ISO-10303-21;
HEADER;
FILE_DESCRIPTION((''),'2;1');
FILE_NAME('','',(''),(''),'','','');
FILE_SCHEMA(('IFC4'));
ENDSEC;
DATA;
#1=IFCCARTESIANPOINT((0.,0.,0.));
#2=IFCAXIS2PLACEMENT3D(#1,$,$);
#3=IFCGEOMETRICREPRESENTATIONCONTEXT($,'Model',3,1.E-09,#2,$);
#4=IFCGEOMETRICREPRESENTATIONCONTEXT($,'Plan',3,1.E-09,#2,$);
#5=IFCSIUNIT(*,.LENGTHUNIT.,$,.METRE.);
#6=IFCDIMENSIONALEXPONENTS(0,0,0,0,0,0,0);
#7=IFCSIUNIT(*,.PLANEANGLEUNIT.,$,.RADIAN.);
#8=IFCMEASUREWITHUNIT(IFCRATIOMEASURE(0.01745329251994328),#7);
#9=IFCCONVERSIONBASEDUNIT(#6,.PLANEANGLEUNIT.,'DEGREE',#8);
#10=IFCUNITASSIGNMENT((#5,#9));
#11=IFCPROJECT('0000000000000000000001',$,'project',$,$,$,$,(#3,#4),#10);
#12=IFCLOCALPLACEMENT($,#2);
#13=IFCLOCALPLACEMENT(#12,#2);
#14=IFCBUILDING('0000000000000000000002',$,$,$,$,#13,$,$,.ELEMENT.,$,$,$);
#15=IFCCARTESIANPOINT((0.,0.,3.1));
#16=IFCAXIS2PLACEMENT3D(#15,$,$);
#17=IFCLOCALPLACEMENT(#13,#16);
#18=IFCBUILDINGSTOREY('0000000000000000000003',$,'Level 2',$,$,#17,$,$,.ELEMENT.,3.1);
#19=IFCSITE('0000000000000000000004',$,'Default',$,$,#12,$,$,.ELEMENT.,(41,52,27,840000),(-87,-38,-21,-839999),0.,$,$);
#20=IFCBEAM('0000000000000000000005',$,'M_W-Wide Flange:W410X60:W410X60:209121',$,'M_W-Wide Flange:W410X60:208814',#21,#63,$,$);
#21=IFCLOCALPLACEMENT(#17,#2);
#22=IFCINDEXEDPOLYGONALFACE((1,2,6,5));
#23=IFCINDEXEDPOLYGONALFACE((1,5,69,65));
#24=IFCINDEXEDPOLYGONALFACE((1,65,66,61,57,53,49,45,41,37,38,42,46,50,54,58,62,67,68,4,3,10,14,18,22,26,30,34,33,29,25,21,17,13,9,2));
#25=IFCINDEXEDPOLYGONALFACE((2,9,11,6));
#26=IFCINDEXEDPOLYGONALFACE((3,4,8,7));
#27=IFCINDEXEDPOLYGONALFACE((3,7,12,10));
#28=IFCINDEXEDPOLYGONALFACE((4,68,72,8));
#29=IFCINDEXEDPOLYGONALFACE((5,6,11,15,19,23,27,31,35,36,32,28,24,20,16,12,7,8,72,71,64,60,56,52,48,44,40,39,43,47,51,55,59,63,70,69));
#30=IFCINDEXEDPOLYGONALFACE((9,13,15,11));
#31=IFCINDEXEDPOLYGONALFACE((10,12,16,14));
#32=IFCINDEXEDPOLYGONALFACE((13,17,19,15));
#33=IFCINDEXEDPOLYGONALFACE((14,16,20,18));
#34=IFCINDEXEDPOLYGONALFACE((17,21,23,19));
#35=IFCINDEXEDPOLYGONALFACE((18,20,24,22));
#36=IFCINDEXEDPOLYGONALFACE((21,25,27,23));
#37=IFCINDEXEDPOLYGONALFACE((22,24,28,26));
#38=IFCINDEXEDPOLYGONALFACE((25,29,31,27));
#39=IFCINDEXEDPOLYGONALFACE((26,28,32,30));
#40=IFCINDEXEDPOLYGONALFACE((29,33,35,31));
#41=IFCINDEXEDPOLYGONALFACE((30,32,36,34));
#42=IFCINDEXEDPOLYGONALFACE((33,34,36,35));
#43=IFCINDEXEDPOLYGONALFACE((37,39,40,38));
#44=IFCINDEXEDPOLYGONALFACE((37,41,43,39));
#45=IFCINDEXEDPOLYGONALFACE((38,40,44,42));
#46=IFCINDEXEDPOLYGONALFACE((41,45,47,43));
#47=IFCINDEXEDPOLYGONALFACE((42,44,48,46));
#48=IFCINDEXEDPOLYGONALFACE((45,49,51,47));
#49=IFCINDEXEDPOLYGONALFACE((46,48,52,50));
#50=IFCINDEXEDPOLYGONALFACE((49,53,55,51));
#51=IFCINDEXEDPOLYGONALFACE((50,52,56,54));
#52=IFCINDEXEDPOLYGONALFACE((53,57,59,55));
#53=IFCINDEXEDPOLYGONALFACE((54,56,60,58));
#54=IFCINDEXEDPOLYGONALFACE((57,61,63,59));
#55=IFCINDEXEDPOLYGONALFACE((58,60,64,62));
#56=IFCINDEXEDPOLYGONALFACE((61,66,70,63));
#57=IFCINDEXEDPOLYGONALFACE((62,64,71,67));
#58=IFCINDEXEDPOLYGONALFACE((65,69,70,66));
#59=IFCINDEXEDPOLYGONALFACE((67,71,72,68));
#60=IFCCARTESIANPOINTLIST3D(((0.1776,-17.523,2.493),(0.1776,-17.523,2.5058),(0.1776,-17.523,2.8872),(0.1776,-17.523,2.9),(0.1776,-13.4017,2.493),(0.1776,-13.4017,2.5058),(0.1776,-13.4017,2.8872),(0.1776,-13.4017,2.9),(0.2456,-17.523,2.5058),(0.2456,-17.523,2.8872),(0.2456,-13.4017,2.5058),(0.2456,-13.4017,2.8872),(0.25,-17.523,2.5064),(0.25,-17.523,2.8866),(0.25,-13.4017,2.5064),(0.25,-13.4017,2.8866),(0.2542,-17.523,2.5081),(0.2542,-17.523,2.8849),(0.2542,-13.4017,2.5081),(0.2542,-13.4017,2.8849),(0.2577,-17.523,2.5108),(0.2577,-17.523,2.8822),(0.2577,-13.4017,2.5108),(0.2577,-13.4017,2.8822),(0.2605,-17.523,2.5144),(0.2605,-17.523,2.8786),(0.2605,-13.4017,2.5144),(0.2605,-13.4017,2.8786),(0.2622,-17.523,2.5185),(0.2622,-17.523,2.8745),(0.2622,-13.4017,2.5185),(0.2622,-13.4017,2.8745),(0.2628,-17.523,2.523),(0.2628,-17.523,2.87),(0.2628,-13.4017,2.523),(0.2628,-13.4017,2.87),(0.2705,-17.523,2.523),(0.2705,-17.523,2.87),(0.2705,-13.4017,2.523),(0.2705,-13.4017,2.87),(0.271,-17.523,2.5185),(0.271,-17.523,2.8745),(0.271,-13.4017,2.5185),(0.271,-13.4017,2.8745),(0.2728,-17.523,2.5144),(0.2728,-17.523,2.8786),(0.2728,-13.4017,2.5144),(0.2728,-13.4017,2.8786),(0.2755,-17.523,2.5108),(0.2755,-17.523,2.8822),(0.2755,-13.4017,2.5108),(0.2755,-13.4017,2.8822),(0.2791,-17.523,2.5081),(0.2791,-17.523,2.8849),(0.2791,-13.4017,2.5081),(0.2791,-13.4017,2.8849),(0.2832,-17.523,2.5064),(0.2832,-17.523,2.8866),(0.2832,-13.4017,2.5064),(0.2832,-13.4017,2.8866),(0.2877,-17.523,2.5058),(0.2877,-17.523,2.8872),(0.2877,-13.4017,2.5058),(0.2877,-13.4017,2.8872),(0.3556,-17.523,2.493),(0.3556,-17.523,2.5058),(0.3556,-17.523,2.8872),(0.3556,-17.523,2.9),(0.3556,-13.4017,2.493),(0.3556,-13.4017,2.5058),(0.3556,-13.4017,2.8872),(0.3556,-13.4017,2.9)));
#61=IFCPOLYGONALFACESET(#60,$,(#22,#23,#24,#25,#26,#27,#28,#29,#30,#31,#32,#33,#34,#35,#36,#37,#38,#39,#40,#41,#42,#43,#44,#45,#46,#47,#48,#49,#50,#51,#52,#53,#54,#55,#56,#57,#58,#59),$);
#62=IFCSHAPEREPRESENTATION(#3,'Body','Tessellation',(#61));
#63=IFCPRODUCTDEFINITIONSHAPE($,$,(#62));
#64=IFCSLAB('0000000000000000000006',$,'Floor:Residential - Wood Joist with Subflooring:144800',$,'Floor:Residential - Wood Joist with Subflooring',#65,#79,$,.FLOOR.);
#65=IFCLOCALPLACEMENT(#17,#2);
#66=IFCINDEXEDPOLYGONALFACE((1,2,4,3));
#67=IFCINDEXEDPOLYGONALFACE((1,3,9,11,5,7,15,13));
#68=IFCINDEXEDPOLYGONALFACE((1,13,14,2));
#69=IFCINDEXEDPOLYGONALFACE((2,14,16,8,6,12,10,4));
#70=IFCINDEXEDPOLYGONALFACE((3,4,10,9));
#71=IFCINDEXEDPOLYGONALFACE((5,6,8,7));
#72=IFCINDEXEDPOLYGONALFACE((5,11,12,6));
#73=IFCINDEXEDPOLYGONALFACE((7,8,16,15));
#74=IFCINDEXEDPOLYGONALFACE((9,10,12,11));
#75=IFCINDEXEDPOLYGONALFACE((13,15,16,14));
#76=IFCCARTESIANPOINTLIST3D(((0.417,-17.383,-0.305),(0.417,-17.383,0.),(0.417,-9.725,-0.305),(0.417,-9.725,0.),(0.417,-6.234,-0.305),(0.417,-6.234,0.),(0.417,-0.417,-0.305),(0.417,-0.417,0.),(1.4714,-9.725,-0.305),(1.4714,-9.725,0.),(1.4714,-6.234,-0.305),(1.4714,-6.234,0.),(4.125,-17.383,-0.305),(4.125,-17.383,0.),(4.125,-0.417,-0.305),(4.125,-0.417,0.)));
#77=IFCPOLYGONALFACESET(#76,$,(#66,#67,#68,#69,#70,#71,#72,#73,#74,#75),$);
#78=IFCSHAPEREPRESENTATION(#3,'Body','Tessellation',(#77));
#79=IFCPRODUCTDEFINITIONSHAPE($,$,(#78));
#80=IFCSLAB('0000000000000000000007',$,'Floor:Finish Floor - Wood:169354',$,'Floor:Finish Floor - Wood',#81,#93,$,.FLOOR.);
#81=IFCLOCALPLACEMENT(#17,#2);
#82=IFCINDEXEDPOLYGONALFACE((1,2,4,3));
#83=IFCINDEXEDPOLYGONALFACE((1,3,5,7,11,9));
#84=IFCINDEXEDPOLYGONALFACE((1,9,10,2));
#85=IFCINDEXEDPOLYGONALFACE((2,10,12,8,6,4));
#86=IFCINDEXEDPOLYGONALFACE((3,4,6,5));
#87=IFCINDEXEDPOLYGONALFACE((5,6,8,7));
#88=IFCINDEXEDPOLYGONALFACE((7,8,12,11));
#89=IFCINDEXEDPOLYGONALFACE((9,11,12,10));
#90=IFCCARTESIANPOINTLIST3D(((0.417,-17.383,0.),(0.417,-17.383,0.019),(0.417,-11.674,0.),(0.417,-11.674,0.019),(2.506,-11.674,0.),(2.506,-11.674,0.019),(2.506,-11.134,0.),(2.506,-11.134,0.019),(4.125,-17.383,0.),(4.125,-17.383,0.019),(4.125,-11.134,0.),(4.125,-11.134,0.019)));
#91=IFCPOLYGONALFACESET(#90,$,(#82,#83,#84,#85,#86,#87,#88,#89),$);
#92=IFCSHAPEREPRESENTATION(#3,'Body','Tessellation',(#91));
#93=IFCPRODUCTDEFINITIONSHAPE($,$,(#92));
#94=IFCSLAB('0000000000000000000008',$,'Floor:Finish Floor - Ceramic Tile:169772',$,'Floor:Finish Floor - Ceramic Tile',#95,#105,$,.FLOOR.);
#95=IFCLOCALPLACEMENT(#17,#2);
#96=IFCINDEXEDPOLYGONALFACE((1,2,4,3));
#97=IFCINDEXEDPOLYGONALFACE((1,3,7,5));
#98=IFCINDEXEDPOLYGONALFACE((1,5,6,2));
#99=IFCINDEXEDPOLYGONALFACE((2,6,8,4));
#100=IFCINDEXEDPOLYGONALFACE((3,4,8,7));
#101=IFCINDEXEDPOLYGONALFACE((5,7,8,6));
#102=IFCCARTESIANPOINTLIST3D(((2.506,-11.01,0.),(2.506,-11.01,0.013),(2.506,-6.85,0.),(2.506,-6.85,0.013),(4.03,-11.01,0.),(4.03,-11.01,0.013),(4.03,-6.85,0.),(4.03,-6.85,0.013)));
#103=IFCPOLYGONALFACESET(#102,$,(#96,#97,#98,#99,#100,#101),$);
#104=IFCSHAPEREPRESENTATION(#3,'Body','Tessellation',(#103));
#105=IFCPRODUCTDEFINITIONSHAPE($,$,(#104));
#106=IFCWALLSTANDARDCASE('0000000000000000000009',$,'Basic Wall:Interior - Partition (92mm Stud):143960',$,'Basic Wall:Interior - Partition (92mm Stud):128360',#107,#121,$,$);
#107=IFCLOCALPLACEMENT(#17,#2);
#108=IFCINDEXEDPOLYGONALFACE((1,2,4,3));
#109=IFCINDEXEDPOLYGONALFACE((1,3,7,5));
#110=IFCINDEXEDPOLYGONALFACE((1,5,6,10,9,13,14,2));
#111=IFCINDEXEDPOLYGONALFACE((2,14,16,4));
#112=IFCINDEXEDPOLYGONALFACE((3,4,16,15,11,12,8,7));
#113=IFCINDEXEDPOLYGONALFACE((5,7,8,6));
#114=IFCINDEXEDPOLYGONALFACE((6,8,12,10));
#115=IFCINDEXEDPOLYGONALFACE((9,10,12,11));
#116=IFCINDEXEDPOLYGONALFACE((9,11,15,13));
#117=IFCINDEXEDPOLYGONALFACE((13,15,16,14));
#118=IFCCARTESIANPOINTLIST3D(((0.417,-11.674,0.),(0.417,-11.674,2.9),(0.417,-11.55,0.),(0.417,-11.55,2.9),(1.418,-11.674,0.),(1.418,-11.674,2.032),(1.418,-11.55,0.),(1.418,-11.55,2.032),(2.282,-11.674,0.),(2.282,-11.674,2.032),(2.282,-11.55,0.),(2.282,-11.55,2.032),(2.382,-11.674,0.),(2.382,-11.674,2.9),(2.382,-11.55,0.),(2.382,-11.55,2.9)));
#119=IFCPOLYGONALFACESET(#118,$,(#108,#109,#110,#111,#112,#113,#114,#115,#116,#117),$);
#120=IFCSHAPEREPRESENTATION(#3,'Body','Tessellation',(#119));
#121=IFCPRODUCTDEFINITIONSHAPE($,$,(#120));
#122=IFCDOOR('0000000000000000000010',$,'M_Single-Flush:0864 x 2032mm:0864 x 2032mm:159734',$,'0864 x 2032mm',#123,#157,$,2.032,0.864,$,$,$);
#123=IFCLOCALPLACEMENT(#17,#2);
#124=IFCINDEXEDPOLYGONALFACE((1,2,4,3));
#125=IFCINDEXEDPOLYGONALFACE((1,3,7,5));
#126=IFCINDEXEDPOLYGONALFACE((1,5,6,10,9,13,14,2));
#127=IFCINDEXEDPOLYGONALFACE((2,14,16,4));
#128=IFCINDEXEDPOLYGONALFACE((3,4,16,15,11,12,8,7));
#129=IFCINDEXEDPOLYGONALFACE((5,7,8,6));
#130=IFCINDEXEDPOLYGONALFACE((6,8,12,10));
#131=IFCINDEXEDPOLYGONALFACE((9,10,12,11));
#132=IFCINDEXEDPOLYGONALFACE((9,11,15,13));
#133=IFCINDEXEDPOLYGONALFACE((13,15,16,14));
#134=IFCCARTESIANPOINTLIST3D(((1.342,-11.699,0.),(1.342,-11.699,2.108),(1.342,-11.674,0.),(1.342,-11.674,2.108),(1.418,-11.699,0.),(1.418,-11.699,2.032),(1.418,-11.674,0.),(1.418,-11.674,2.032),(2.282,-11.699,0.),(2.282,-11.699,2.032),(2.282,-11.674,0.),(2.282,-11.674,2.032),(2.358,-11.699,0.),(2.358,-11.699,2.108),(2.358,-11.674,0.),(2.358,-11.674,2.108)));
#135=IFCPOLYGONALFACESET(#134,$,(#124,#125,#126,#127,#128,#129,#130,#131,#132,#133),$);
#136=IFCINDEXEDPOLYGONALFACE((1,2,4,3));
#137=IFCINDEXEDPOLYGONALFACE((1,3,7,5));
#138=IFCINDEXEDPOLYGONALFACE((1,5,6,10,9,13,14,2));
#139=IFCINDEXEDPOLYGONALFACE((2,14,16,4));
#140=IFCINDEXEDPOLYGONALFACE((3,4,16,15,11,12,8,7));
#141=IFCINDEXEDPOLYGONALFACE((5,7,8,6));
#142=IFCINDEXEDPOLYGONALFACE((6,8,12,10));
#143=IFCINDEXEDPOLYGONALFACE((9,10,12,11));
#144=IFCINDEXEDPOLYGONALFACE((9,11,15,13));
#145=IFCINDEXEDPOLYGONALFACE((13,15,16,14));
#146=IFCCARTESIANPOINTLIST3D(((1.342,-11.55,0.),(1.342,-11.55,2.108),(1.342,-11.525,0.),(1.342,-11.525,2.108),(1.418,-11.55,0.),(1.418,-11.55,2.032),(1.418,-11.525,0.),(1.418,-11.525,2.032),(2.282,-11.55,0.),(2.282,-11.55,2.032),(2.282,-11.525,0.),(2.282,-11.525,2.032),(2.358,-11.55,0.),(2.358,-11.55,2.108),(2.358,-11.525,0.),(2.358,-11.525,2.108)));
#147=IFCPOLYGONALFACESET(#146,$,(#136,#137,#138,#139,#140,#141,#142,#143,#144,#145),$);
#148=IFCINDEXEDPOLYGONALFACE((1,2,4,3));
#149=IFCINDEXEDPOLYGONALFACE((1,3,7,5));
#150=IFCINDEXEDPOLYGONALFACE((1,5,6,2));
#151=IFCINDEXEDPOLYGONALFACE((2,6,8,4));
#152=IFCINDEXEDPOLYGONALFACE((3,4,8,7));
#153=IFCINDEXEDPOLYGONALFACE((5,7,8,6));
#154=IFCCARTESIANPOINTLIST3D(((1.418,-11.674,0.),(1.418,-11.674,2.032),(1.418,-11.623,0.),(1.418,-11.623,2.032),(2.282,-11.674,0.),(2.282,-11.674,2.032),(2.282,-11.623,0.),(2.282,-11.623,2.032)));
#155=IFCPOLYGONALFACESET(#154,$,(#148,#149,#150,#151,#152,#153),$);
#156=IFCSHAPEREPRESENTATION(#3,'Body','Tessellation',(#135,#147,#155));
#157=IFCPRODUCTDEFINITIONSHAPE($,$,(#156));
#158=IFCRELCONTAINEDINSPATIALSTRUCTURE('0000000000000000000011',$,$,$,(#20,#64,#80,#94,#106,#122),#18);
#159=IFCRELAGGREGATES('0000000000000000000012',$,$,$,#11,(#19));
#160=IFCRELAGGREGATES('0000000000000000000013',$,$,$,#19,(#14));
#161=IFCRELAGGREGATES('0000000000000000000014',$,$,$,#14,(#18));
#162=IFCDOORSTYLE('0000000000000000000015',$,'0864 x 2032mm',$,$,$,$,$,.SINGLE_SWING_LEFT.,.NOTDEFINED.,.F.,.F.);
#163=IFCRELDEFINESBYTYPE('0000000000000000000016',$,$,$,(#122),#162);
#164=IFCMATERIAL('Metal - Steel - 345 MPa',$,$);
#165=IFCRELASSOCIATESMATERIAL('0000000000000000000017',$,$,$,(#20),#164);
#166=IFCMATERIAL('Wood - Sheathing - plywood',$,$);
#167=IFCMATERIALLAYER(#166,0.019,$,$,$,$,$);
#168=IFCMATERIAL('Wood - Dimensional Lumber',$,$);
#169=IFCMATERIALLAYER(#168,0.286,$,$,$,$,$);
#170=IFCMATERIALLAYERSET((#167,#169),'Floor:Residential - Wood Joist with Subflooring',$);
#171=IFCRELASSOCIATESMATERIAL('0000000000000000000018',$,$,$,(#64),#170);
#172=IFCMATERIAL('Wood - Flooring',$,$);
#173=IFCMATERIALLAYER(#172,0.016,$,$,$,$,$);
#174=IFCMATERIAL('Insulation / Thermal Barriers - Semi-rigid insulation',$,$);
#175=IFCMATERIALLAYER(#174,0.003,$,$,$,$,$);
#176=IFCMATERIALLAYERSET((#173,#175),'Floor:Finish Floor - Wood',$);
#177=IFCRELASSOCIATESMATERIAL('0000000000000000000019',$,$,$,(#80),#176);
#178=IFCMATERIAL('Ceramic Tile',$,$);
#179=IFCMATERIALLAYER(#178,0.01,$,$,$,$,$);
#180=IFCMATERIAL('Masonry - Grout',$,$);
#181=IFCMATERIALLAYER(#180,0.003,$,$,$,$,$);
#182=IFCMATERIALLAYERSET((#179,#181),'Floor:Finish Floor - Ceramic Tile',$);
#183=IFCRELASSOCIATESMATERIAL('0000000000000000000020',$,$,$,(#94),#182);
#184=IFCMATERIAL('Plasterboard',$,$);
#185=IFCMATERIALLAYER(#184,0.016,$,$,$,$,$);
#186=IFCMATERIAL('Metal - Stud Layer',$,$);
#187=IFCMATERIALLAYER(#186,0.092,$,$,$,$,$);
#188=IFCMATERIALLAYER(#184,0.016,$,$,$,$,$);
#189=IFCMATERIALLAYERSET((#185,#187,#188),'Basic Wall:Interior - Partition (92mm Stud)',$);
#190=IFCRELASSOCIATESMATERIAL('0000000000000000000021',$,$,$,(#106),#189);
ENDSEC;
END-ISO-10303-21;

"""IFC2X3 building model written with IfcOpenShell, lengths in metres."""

from ifc_helpers import new_model, entity, si_unit, converted_unit, frame, frame_2d, origin, origin_2d_with_axis, place, context, project, spatial, polyline, circle_curve, parameter, trimmed, segment, composite_curve, rectangle, outline, extrude, source, transform, mapped, material, layer, layer_set, layer_usage, type_object, type_shapes, element, fill, save


model = new_model("IFC2X3")

# Units and contexts
model_context = context("Model", 3, precision=1e-09, world=origin())
plan_context = context("Plan", 3, precision=1e-09, world=origin())
ifc_project = project(units=[si_unit("LENGTHUNIT", "METRE"), converted_unit("PLANEANGLEUNIT", "DEGREE", entity("IfcRatioMeasure", 0.01745329251994328), si_unit("PLANEANGLEUNIT", "RADIAN"), dimensions=[0, 0, 0, 0, 0, 0, 0])], contexts=[model_context, plan_context])

# Site, building, storey
site_placement = place(None, origin())
site = spatial("IfcSite", under=ifc_project, at=site_placement, Name="Default", CompositionType="ELEMENT", RefLatitude=(41, 52, 27, 840000), RefLongitude=(-87, -38, -21, -839999), RefElevation=0.0)
building_placement = place(site_placement, origin())
building = spatial("IfcBuilding", under=site, at=building_placement, CompositionType="ELEMENT")
storey_placement = place(building_placement, frame((0.0, 0.0, 3.1)))
storey = spatial("IfcBuildingStorey", under=building, at=storey_placement, Name="Level 2", CompositionType="ELEMENT", Elevation=3.1)

# Beam
ifc_material_1 = material(Name="Metal - Steel - 345 MPa")
beam_placement = place(storey_placement, frame((0.2666, -13.4017, 2.9), z_axis=(0.0, 0.0, 1.0), x_axis=(-1.0, 0.0, 0.0)))
element("IfcBeam", 1, at=beam_placement, inside=storey, material=ifc_material_1, Name="M_W-Wide Flange:W410X60:W410X60:209121", ObjectType="M_W-Wide Flange:W410X60:208814", context=model_context, shape_type="SweptSolid", body=[
    extrude(outline(composite_curve([segment(polyline([(0.1907, -0.089), (0.2035, -0.089)]), True, "CONTINUOUS"), segment(polyline([(0.2035, -0.089), (0.2035, 0.089)]), True, "CONTINUOUS"), segment(polyline([(0.2035, 0.089), (0.1907, 0.089)]), True, "CONTINUOUS"), segment(polyline([(0.1907, 0.089), (0.1907, 0.021)]), True, "CONTINUOUS"), segment(trimmed(circle_curve(frame_2d((0.1735, 0.021), x_axis=(1.0, 0.0)), 0.0172), [parameter(270.0)], [parameter(360.0)], True, "PARAMETER"), False, "CONTINUOUS"), segment(polyline([(0.1735, 0.0038), (-0.1735, 0.0038)]), True, "CONTINUOUS"), segment(trimmed(circle_curve(frame_2d((-0.1735, 0.021), x_axis=(0.0, -1.0)), 0.0172), [parameter(270.0)], [parameter(360.0)], True, "PARAMETER"), False, "CONTINUOUS"), segment(polyline([(-0.1907, 0.021), (-0.1907, 0.089)]), True, "CONTINUOUS"), segment(polyline([(-0.1907, 0.089), (-0.2035, 0.089)]), True, "CONTINUOUS"), segment(polyline([(-0.2035, 0.089), (-0.2035, -0.089)]), True, "CONTINUOUS"), segment(polyline([(-0.2035, -0.089), (-0.1907, -0.089)]), True, "CONTINUOUS"), segment(polyline([(-0.1907, -0.089), (-0.1907, -0.0211)]), True, "CONTINUOUS"), segment(trimmed(circle_curve(frame_2d((-0.1735, -0.0211), x_axis=(-1.0, 0.0)), 0.0172), [parameter(270.0)], [parameter(0.0)], True, "PARAMETER"), False, "CONTINUOUS"), segment(polyline([(-0.1735, -0.0039), (0.1735, -0.0039)]), True, "CONTINUOUS"), segment(trimmed(circle_curve(frame_2d((0.1735, -0.0211), x_axis=(0.0, 1.0)), 0.0172), [parameter(270.0)], [parameter(0.0)], True, "PARAMETER"), False, "CONTINUOUS"), segment(polyline([(0.1907, -0.0211), (0.1907, -0.089)]), True, "CONTINUOUS")], self_intersect=False)), frame((0.0, 4.1213, -0.2035), z_axis=(0.0, -1.0, 0.0), x_axis=(0.0, 0.0, -1.0)), (0.0, 0.0, 1.0), 4.1213),
])

# Slabs
ifc_material_2 = material(Name="Wood - Sheathing - plywood")
ifc_layer_1 = layer(ifc_material_2, 0.019)
ifc_material_3 = material(Name="Wood - Dimensional Lumber")
ifc_layer_2 = layer(ifc_material_3, 0.286)
ifc_layer_set_1 = layer_set([ifc_layer_1, ifc_layer_2], Name="Floor:Residential - Wood Joist with Subflooring")
ifc_layer_usage_1 = layer_usage(ifc_layer_set_1, "AXIS3", "POSITIVE", 0.0)
slab_1_placement = place(storey_placement, frame((0.417, -17.383, -0.305)))
element("IfcSlab", 2, at=slab_1_placement, inside=storey, material=ifc_layer_usage_1, Name="Floor:Residential - Wood Joist with Subflooring:144800", ObjectType="Floor:Residential - Wood Joist with Subflooring", PredefinedType="FLOOR", context=model_context, shape_type="SweptSolid", body=[
    extrude(outline(polyline([(-1.854, 8.483), (-1.854, -8.483), (1.854, -8.483), (1.854, -0.825), (0.7996, -0.825), (0.7996, 2.666), (1.854, 2.666), (1.854, 8.483), (-1.854, 8.483)])), frame((1.854, 8.483, 0.305), z_axis=(0.0, 0.0, -1.0), x_axis=(-1.0, 0.0, 0.0)), (0.0, 0.0, 1.0), 0.305),
])
ifc_material_4 = material(Name="Wood - Flooring")
ifc_layer_3 = layer(ifc_material_4, 0.016)
ifc_material_5 = material(Name="Insulation / Thermal Barriers - Semi-rigid insulation")
ifc_layer_4 = layer(ifc_material_5, 0.003)
ifc_layer_set_2 = layer_set([ifc_layer_3, ifc_layer_4], Name="Floor:Finish Floor - Wood")
ifc_layer_usage_2 = layer_usage(ifc_layer_set_2, "AXIS3", "POSITIVE", 0.0)
slab_2_placement = place(storey_placement, frame((0.417, -17.383, 0.0)))
element("IfcSlab", 3, at=slab_2_placement, inside=storey, material=ifc_layer_usage_2, Name="Floor:Finish Floor - Wood:169354", ObjectType="Floor:Finish Floor - Wood", PredefinedType="FLOOR", context=model_context, shape_type="SweptSolid", body=[
    extrude(outline(polyline([(-1.854, -3.1245), (1.854, -3.1245), (1.854, 2.5845), (-0.235, 2.5845), (-0.235, 3.1245), (-1.854, 3.1245), (-1.854, -3.1245)])), frame((1.854, 3.1245, 0.019), z_axis=(0.0, 0.0, -1.0), x_axis=(-1.0, 0.0, 0.0)), (0.0, 0.0, 1.0), 0.019),
])
ifc_material_6 = material(Name="Ceramic Tile")
ifc_layer_5 = layer(ifc_material_6, 0.01)
ifc_material_7 = material(Name="Masonry - Grout")
ifc_layer_6 = layer(ifc_material_7, 0.003)
ifc_layer_set_3 = layer_set([ifc_layer_5, ifc_layer_6], Name="Floor:Finish Floor - Ceramic Tile")
ifc_layer_usage_3 = layer_usage(ifc_layer_set_3, "AXIS3", "POSITIVE", 0.0)
slab_3_placement = place(storey_placement, frame((2.506, -11.01, 0.0)))
element("IfcSlab", 4, at=slab_3_placement, inside=storey, material=ifc_layer_usage_3, Name="Floor:Finish Floor - Ceramic Tile:169772", ObjectType="Floor:Finish Floor - Ceramic Tile", PredefinedType="FLOOR", context=model_context, shape_type="SweptSolid", body=[
    extrude(rectangle(XDim=4.16, YDim=1.524, at=frame_2d((0.0, 0.0), x_axis=(0.0, -1.0))), frame((0.762, 2.08, 0.013), z_axis=(0.0, 0.0, -1.0), x_axis=(-1.0, 0.0, 0.0)), (0.0, 0.0, 1.0), 0.013),
])

# Shared definitions
ifc_material_8 = material(Name="Metal - Stud Layer")
ifc_material_9 = material(Name="Plasterboard")

# Wall, opening, door
ifc_layer_7 = layer(ifc_material_9, 0.016)
ifc_layer_8 = layer(ifc_material_8, 0.092)
ifc_layer_9 = layer(ifc_material_9, 0.016)
ifc_layer_set_4 = layer_set([ifc_layer_7, ifc_layer_8, ifc_layer_9], Name="Basic Wall:Interior - Partition (92mm Stud)")
ifc_layer_usage_4 = layer_usage(ifc_layer_set_4, "AXIS2", "NEGATIVE", 0.062)
wall_1_placement = place(storey_placement, frame((2.382, -11.612, 0.0), z_axis=(0.0, 0.0, 1.0), x_axis=(-1.0, 0.0, 0.0)))
wall_1 = element("IfcWallStandardCase", 5, at=wall_1_placement, inside=storey, material=ifc_layer_usage_4, Name="Basic Wall:Interior - Partition (92mm Stud):143960", ObjectType="Basic Wall:Interior - Partition (92mm Stud):128360", context=model_context, shape_type="SweptSolid", body=[
    extrude(rectangle(XDim=1.965, YDim=0.124, at=frame_2d((0.9825, 0.0), x_axis=(-1.0, 0.0))), origin(), (0.0, 0.0, 1.0), 2.9),
])
opening_1_placement = place(wall_1_placement, frame((0.1, -0.062, 0.0)))
opening_1 = element("IfcOpeningElement", 6, at=opening_1_placement, cuts=wall_1, ObjectType="Opening", context=model_context, shape_type="SweptSolid", body=[
    extrude(rectangle(XDim=0.864, YDim=2.032, at=frame_2d((1.016, 0.432), x_axis=(0.0, -1.0))), frame((0.0, 0.0, 0.0), z_axis=(0.0, 1.0, 0.0), x_axis=(0.0, 0.0, 1.0)), (0.0, 0.0, 1.0), 0.124),
])
door_style = type_object("IfcDoorStyle", Name="0864 x 2032mm", ConstructionType="NOTDEFINED", OperationType="SINGLE_SWING_LEFT", ParameterTakesPrecedence=False, Sizeable=False)
shared_shape_1 = source(origin(), model_context, "Body", "SweptSolid", [
    extrude(outline(polyline([(-0.508, -1.073), (0.508, -1.073), (0.508, 1.035), (0.432, 1.035), (0.432, -0.997), (-0.432, -0.997), (-0.432, 1.035), (-0.508, 1.035), (-0.508, -1.073)])), frame((0.432, 0.149, 1.035), z_axis=(0.0, -1.0, 0.0), x_axis=(-1.0, 0.0, 0.0)), (0.0, 0.0, 1.0), 0.025),
    extrude(outline(polyline([(-1.073, -0.508), (1.035, -0.508), (1.035, -0.432), (-0.997, -0.432), (-0.997, 0.432), (1.035, 0.432), (1.035, 0.508), (-1.073, 0.508), (-1.073, -0.508)])), frame((0.432, 0.0, 1.035), z_axis=(0.0, -1.0, 0.0), x_axis=(0.0, 0.0, -1.0)), (0.0, 0.0, 1.0), 0.025),
    extrude(rectangle(XDim=0.864, YDim=0.051, at=origin_2d_with_axis()), frame((0.432, 0.0985, 0.0)), (0.0, 0.0, 1.0), 2.032),
])
type_shapes(door_style, [shared_shape_1])
door_placement = place(opening_1_placement, origin())
door = element("IfcDoor", 7, at=door_placement, inside=storey, type_object=door_style, Name="M_Single-Flush:0864 x 2032mm:0864 x 2032mm:159734", ObjectType="0864 x 2032mm", OverallHeight=2.032, OverallWidth=0.864, context=model_context, shape_type="MappedRepresentation", body=[
    mapped(shared_shape_1, transform((0.0, 0.0, 0.0), scale=1.0)),
])
fill(opening_1, door)

save(model, "model.ifc")
